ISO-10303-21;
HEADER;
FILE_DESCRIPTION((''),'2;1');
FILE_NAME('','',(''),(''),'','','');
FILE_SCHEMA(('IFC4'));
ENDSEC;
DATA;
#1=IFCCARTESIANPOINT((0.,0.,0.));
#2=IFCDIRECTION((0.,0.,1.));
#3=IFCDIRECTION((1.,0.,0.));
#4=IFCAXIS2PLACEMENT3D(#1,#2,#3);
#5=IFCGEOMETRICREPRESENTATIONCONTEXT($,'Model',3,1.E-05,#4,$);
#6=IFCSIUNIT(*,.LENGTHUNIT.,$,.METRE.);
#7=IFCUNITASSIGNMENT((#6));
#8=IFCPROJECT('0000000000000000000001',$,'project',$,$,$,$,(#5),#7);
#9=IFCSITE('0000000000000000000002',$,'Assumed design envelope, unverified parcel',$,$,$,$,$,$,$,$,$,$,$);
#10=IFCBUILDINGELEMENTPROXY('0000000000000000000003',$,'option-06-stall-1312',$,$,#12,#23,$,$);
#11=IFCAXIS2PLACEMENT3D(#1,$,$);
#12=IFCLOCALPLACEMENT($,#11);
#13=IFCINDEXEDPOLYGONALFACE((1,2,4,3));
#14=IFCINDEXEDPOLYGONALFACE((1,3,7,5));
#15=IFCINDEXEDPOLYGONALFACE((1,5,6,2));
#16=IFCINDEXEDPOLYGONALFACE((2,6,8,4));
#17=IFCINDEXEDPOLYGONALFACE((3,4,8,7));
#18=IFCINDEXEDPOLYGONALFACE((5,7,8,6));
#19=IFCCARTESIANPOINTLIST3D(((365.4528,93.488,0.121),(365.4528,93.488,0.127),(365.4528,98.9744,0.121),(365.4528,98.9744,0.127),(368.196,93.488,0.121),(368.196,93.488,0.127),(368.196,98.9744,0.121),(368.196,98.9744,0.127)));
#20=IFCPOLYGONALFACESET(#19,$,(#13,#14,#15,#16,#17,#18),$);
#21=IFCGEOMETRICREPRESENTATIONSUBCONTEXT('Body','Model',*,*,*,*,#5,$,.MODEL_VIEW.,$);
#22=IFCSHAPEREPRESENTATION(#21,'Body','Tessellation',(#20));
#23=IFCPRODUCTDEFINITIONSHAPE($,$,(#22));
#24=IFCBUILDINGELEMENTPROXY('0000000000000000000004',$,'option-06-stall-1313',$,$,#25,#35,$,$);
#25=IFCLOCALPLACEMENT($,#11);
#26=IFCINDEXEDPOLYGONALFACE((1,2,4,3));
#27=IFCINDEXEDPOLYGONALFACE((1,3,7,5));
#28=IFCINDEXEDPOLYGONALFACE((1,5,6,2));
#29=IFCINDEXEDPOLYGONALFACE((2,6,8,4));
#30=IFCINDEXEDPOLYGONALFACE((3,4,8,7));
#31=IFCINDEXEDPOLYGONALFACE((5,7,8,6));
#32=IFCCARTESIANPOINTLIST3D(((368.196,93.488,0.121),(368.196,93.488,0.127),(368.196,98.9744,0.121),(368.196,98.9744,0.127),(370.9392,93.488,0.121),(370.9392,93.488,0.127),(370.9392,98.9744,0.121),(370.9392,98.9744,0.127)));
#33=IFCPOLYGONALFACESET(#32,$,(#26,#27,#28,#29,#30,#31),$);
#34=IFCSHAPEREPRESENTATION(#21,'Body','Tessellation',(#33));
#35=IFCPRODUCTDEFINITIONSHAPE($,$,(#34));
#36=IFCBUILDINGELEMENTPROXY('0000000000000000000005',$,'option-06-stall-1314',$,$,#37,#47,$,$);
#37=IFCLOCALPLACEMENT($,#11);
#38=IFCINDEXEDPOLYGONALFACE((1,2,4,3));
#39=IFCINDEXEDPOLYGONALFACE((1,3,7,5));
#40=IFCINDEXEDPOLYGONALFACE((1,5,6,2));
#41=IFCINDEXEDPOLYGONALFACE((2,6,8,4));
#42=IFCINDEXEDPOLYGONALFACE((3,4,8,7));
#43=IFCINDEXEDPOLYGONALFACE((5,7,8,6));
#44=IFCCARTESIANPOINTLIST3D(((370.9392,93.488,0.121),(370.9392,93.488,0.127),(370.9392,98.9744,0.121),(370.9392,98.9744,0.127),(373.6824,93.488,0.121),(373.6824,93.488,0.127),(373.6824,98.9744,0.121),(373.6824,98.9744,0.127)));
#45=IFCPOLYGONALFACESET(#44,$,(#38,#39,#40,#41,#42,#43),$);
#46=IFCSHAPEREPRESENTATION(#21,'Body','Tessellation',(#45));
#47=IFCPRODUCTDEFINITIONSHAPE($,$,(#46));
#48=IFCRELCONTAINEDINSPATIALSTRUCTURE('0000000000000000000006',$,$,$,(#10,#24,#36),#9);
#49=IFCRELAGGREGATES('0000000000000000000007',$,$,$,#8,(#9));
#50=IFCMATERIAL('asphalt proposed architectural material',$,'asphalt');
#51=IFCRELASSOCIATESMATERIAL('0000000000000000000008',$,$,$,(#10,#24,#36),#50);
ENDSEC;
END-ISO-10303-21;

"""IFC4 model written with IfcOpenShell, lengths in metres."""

from ifc_helpers import new_model, si_unit, frame, origin_with_axes, place, context, subcontext, project, spatial, rectangle, extrude, material, element, save


model = new_model("IFC4")

# Units and contexts
model_context = context("Model", 3, precision=1e-05, world=origin_with_axes())
body_context = subcontext(model_context, "Body", "Model", "MODEL_VIEW")
ifc_project = project(units=[si_unit("LENGTHUNIT", "METRE")], contexts=[model_context])

# Site
site = spatial("IfcSite", under=ifc_project, Name="Assumed design envelope, unverified parcel")

# Building element proxies
ifc_material = material(Name="asphalt proposed architectural material", Category="asphalt")
for number, where, z_axis, x_axis, name in (
    (1, (366.8244, 96.2312, 0.121), (0.0, 0.0, 1.0), (1.0, 0.0, 0.0), "option-06-stall-1312"),
    (2, (369.5676, 96.2312, 0.121), (0.0, 0.0, 1.0), (1.0, 0.0, 0.0), "option-06-stall-1313"),
    (3, (372.3108, 96.2312, 0.121), (0.0, 0.0, 1.0), (1.0, 0.0, 0.0), "option-06-stall-1314"),
):
    element("IfcBuildingElementProxy", number, at=place(None, frame(where, z_axis=z_axis, x_axis=x_axis)), inside=site, material=ifc_material, Name=name, context=body_context, shape_type="SweptSolid", body=[
        extrude(rectangle(XDim=2.7432, YDim=5.4864), origin_with_axes(), (0.0, 0.0, 1.0), 0.006),
    ])

save(model, "model.ifc")
